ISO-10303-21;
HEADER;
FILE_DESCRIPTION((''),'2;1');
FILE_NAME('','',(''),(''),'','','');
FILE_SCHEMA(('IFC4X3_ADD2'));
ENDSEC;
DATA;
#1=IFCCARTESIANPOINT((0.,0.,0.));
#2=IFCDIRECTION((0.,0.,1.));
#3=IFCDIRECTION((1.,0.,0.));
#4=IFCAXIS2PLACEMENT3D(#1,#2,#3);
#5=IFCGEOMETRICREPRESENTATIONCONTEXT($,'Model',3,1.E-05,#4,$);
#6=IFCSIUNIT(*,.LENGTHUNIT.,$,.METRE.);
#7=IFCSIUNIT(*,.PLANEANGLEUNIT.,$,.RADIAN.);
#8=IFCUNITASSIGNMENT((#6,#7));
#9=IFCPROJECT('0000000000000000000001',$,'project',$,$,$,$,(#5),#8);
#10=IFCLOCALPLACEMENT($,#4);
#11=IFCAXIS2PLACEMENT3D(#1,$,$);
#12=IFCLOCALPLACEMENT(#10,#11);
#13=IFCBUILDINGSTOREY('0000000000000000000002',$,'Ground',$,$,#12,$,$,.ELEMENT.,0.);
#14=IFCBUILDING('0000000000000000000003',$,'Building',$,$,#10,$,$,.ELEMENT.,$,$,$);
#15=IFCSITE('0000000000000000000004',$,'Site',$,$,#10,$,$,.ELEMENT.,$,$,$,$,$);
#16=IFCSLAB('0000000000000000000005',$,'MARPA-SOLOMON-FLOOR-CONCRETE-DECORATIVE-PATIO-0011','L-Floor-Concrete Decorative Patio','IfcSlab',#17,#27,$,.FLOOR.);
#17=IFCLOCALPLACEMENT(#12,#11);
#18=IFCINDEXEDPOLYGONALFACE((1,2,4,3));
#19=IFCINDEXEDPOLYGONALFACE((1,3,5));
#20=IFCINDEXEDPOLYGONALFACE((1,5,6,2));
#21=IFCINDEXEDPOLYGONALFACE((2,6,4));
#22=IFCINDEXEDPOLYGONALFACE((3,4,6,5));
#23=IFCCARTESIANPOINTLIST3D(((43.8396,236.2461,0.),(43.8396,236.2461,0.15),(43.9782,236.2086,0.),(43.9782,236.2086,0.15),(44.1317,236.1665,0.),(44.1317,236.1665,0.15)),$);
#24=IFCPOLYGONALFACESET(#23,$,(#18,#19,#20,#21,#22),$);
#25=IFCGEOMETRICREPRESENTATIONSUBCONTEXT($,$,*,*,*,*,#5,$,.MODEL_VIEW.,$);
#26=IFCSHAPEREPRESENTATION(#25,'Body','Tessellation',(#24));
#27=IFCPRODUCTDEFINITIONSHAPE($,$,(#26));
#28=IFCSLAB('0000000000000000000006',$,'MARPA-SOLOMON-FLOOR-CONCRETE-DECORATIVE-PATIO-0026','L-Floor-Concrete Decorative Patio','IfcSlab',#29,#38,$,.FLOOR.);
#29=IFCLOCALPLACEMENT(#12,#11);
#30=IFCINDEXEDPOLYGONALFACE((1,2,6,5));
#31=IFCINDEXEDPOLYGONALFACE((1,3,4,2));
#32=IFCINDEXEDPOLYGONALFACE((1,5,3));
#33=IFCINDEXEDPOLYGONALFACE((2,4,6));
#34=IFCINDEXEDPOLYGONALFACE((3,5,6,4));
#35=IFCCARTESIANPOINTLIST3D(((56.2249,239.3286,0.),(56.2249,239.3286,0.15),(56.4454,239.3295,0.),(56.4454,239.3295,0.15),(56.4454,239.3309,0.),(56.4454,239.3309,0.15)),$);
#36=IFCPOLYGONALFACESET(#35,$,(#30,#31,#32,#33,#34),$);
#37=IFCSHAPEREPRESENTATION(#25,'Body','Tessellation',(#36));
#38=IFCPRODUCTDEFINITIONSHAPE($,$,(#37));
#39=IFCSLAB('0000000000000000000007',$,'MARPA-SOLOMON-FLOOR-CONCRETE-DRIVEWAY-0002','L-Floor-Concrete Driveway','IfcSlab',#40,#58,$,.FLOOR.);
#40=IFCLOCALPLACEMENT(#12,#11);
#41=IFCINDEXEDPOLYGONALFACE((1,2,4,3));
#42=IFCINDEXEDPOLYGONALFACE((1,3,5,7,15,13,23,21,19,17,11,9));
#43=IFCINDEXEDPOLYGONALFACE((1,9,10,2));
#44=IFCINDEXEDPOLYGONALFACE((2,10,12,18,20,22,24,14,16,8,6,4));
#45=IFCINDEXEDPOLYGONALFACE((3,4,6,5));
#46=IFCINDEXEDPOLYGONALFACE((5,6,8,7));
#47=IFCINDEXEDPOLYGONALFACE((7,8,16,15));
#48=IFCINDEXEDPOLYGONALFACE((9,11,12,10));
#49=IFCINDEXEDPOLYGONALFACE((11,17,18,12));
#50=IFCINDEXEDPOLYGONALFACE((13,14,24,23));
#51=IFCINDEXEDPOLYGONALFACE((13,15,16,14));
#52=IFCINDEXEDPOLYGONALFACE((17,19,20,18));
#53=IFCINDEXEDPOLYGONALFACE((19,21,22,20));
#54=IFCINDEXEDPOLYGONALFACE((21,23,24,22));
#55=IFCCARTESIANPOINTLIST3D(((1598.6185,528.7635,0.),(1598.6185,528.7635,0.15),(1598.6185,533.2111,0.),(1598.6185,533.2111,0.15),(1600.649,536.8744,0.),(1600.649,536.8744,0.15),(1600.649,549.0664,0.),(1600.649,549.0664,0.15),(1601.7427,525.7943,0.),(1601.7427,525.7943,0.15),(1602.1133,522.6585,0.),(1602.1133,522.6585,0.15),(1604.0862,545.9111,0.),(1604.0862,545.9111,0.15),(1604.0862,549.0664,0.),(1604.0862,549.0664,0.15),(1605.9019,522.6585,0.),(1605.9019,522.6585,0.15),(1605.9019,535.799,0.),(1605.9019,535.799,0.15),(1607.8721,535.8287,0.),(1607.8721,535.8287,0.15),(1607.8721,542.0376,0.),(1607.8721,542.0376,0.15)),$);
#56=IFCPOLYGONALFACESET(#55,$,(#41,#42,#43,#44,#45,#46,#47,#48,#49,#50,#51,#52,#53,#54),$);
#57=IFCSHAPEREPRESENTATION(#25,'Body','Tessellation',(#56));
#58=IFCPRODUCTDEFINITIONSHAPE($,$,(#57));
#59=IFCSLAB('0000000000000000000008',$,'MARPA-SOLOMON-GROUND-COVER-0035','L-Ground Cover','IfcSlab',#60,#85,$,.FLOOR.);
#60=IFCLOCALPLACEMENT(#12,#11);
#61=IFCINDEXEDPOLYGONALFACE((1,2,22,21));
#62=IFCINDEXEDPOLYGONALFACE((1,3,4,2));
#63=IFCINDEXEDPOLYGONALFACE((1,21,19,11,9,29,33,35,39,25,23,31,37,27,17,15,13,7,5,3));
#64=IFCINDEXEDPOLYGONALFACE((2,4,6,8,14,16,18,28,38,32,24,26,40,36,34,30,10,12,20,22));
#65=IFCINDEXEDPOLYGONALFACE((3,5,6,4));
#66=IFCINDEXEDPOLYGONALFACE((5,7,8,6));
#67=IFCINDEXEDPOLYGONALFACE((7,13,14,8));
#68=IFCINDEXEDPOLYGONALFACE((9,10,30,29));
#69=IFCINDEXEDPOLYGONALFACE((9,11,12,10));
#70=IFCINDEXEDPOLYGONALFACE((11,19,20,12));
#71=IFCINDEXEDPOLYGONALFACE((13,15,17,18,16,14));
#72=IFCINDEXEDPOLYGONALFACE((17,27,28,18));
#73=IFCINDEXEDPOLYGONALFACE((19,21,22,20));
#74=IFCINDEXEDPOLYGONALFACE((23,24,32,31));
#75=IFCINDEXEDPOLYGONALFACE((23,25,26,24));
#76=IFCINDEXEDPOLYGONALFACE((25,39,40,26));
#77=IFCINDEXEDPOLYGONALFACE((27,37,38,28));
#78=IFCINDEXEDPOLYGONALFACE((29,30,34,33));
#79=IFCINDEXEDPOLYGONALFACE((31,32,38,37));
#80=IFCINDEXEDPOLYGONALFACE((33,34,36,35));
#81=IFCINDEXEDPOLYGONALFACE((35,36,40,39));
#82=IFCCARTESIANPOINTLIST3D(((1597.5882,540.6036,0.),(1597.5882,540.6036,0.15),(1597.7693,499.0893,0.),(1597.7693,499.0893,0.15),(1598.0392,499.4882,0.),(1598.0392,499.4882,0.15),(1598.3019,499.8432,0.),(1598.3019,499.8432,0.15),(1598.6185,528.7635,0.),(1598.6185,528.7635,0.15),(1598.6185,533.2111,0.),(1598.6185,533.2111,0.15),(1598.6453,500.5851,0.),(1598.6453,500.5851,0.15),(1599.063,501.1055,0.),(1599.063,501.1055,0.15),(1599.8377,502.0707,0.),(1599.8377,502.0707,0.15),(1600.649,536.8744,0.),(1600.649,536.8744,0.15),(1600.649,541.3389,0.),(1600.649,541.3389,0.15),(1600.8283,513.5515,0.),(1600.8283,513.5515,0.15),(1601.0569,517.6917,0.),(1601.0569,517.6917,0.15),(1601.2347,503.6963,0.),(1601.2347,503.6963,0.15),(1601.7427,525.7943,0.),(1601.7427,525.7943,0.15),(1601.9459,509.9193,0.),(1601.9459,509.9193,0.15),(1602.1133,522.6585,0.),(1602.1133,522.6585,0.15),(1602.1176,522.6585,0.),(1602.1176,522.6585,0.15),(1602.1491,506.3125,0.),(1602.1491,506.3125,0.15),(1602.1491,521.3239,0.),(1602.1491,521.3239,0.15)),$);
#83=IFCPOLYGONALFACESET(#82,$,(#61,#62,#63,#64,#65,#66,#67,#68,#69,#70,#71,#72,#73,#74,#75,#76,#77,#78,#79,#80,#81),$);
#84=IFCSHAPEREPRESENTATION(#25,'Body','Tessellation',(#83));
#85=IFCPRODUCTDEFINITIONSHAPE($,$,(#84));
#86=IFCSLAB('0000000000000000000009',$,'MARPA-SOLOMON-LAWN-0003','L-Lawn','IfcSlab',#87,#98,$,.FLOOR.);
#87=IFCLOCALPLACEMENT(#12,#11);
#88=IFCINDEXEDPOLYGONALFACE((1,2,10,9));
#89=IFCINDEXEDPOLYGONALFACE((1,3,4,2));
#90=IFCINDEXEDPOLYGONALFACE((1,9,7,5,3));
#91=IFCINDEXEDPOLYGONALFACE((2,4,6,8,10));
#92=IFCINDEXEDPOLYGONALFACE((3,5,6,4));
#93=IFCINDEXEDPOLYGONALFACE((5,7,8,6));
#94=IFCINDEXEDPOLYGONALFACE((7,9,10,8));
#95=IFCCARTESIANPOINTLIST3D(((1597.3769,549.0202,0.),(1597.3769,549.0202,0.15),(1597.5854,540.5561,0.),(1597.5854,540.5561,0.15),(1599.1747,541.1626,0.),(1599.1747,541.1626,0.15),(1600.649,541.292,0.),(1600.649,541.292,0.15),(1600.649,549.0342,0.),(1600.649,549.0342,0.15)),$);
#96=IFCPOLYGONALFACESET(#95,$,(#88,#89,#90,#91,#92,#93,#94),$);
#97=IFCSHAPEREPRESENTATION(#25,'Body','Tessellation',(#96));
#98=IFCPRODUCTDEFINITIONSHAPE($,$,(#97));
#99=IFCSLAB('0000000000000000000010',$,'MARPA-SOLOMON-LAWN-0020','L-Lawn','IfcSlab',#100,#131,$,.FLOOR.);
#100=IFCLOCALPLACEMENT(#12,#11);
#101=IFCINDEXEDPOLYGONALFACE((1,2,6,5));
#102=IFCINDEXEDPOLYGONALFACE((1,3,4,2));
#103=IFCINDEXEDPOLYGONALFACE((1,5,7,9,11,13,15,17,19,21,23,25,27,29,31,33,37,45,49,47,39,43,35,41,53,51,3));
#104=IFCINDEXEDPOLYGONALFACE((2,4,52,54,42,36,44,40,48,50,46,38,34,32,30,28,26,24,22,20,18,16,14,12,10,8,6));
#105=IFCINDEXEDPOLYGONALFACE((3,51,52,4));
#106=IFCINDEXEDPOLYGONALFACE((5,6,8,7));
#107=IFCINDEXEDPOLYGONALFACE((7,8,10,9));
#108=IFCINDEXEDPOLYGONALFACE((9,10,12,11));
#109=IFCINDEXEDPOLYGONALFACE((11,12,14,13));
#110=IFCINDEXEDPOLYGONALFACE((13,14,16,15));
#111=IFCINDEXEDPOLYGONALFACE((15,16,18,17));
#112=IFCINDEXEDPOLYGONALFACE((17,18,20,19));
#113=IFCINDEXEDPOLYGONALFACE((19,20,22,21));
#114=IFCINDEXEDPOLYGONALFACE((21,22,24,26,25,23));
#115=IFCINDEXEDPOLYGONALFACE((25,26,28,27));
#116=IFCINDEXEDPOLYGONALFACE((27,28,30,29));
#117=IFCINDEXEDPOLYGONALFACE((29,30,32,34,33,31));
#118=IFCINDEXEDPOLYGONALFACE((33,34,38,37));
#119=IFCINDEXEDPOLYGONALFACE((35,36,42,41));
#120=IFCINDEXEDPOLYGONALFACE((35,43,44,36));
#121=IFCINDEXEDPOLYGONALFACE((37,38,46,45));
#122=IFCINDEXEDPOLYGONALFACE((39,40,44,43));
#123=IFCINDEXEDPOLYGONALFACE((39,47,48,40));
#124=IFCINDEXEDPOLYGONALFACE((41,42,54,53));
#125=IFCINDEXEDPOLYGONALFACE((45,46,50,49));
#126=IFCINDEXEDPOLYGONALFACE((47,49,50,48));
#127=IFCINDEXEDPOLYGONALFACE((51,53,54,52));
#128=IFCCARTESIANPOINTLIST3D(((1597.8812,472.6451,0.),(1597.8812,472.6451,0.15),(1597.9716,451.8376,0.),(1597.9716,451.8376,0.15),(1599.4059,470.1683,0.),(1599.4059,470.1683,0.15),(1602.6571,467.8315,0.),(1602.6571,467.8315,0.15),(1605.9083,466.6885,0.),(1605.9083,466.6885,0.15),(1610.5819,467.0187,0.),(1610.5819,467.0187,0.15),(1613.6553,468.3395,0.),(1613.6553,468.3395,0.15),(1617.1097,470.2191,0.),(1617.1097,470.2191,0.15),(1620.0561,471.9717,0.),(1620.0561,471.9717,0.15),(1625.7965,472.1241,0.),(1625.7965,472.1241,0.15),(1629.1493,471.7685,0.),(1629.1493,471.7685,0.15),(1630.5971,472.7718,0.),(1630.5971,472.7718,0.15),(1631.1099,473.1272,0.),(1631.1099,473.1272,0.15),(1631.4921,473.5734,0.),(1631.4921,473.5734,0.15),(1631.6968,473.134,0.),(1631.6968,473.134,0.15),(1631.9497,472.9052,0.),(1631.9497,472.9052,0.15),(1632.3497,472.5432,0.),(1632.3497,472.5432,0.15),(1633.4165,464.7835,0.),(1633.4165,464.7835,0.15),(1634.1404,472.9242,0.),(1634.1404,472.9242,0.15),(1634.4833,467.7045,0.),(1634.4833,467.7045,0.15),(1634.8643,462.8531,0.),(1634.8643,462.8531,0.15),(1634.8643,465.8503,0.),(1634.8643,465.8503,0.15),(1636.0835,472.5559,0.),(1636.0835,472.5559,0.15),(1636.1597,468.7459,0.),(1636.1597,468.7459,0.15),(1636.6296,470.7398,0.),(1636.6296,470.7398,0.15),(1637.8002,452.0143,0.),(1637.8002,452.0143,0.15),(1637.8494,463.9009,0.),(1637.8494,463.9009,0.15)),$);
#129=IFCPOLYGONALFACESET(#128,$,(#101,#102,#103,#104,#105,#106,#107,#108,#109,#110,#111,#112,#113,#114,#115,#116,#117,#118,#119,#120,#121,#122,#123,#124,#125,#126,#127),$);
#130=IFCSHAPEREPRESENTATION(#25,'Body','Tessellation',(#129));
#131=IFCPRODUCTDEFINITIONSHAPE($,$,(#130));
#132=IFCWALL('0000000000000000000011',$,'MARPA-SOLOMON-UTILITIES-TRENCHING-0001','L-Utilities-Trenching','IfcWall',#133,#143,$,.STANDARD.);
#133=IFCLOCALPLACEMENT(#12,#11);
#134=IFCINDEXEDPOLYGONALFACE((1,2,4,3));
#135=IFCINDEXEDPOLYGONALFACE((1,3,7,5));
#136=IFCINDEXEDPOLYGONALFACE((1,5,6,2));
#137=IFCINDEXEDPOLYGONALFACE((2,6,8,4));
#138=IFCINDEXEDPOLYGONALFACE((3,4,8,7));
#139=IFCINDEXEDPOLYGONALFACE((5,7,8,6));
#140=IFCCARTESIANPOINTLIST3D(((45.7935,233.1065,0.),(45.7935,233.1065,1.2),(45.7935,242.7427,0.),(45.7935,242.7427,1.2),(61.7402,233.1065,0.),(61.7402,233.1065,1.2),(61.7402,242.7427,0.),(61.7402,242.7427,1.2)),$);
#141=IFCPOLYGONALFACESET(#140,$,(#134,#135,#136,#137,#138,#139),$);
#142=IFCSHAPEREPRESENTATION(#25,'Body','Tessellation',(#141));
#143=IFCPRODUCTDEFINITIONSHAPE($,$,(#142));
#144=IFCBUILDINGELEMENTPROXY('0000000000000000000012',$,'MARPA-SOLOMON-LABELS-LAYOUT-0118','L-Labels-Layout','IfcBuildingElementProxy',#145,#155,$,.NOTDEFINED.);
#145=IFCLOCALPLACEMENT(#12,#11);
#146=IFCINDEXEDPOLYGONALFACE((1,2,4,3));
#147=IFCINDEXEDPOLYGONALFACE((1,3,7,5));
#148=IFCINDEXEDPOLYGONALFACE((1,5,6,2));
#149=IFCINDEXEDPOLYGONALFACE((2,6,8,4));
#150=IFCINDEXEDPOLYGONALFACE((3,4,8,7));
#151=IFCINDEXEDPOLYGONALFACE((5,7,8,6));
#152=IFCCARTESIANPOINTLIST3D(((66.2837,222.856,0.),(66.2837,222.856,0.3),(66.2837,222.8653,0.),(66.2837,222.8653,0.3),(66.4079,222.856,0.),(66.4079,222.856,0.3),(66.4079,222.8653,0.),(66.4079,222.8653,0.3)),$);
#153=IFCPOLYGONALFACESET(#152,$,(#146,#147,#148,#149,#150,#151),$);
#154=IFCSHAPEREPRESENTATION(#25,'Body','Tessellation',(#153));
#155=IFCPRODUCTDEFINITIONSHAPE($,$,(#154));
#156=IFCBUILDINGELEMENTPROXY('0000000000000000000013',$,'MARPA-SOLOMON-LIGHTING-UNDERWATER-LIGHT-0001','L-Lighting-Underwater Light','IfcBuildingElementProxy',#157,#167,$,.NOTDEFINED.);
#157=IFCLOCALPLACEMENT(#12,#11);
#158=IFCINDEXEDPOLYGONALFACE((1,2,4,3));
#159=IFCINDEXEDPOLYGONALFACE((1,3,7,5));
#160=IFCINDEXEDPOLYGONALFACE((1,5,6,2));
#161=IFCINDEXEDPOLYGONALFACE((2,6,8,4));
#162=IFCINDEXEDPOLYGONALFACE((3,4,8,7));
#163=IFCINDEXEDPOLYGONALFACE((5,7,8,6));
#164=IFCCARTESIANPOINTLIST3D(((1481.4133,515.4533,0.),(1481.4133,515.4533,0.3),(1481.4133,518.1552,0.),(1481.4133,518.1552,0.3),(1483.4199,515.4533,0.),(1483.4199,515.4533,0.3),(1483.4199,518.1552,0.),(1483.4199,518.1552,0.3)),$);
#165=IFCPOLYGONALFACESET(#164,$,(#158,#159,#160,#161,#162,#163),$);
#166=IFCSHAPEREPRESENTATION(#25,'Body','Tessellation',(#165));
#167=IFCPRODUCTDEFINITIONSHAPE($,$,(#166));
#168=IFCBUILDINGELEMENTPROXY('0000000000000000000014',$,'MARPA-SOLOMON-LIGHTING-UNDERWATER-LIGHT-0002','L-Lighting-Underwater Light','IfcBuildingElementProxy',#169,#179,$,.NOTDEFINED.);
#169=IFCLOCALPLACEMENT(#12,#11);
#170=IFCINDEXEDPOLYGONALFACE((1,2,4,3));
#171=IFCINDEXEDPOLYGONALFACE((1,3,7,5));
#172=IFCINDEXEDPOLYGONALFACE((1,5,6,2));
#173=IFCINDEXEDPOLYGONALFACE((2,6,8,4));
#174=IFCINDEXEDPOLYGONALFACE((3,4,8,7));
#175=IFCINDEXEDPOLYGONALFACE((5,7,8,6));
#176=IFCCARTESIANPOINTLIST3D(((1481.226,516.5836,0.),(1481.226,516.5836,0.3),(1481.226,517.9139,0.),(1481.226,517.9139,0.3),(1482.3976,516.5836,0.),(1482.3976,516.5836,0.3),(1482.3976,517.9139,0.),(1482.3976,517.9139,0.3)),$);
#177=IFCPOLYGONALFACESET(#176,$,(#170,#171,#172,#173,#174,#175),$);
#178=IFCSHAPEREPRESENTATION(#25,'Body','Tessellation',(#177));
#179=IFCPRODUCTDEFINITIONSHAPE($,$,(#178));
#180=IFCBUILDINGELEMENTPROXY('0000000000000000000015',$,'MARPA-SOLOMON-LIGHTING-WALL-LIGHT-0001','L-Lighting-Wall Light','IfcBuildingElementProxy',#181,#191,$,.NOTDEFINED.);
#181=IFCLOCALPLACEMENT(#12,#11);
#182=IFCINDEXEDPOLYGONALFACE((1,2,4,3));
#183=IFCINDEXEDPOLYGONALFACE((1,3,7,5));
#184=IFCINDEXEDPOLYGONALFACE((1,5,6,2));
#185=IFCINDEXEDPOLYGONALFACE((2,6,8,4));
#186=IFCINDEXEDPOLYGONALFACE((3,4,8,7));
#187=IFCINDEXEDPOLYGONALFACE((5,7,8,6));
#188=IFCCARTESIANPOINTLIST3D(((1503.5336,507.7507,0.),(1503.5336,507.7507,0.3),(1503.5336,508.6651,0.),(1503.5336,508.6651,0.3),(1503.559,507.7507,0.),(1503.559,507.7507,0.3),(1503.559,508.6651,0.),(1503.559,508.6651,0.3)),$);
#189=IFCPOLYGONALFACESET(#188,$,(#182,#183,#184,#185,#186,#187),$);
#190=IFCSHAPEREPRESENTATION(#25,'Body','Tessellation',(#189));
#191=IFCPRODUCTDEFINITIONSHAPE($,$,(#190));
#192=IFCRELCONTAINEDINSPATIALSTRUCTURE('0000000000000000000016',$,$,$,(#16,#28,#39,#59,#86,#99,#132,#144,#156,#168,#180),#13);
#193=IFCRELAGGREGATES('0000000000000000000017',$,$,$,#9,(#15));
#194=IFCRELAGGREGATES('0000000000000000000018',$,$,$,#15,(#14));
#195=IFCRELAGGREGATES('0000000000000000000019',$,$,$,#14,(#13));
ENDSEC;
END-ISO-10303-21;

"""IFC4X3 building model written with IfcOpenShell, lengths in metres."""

from ifc_helpers import new_model, si_unit, frame, frame_2d, origin, origin_with_axes, place, context, subcontext, project, spatial, polyline, rectangle, outline, extrude, element, save


model = new_model("IFC4X3")

# Units and contexts
model_context = context("Model", 3, precision=1e-05, world=origin_with_axes())
sub_context = subcontext(model_context, None, None, "MODEL_VIEW")
ifc_project = project(units=[si_unit("LENGTHUNIT", "METRE"), si_unit("PLANEANGLEUNIT", "RADIAN")], contexts=[model_context])

# Site, building, storey
placement = place(None, origin_with_axes())
site = spatial("IfcSite", under=ifc_project, at=placement, Name="Site", CompositionType="ELEMENT")
building = spatial("IfcBuilding", under=site, at=placement, Name="Building", CompositionType="ELEMENT")
storey_placement = place(placement, origin())
storey = spatial("IfcBuildingStorey", under=building, at=storey_placement, Name="Ground", CompositionType="ELEMENT", Elevation=0.0)

# Slabs
slab_1_placement = place(storey_placement, frame((43.8396, 236.1665, 0.0)))
element("IfcSlab", 1, at=slab_1_placement, inside=storey, Name="MARPA-SOLOMON-FLOOR-CONCRETE-DECORATIVE-PATIO-0011", Description="L-Floor-Concrete Decorative Patio", ObjectType="IfcSlab", PredefinedType="FLOOR", context=sub_context, shape_type="SweptSolid", body=[
    extrude(outline(polyline([(0.0, 0.0796), (0.2921, 0.0), (0.1386, 0.0421), (0.0, 0.0796)])), origin(), (0.0, 0.0, 1.0), 0.15),
])
slab_2_placement = place(storey_placement, frame((56.2249, 239.3286, 0.0)))
element("IfcSlab", 2, at=slab_2_placement, inside=storey, Name="MARPA-SOLOMON-FLOOR-CONCRETE-DECORATIVE-PATIO-0026", Description="L-Floor-Concrete Decorative Patio", ObjectType="IfcSlab", PredefinedType="FLOOR", context=sub_context, shape_type="SweptSolid", body=[
    extrude(outline(polyline([(0.0, 0.0), (0.2205, 0.001), (0.2205, 0.0023), (0.0, 0.0)])), origin(), (0.0, 0.0, 1.0), 0.15),
])
slab_3_placement = place(storey_placement, frame((1598.6185, 522.6585, 0.0)))
element("IfcSlab", 3, at=slab_3_placement, inside=storey, Name="MARPA-SOLOMON-FLOOR-CONCRETE-DRIVEWAY-0002", Description="L-Floor-Concrete Driveway", ObjectType="IfcSlab", PredefinedType="FLOOR", context=sub_context, shape_type="SweptSolid", body=[
    extrude(outline(polyline([(2.0305, 26.4079), (2.0305, 14.2159), (0.0, 10.5527), (0.0, 6.105), (3.1242, 3.1359), (3.4948, 0.0), (7.2834, 0.0), (7.2834, 13.1405), (9.2536, 13.1702), (9.2536, 19.3792), (5.4677, 23.2527), (5.4677, 26.4079), (2.0305, 26.4079)])), origin(), (0.0, 0.0, 1.0), 0.15),
])
slab_4_placement = place(storey_placement, frame((1597.5882, 499.0893, 0.0)))
element("IfcSlab", 4, at=slab_4_placement, inside=storey, Name="MARPA-SOLOMON-GROUND-COVER-0035", Description="L-Ground Cover", ObjectType="IfcSlab", PredefinedType="FLOOR", context=sub_context, shape_type="SweptSolid", body=[
    extrude(outline(polyline([(0.7137, 0.7538), (1.0571, 1.4958), (1.4748, 2.0162), (2.2495, 2.9814), (3.6465, 4.607), (4.5609, 7.2232), (4.3577, 10.83), (3.2401, 14.4622), (3.4687, 18.6024), (4.5609, 22.2346), (4.5294, 23.5691), (4.5251, 23.5691), (4.1545, 26.705), (1.0303, 29.6741), (1.0303, 34.1218), (3.0608, 37.785), (3.0608, 42.2496), (0.0, 41.5143), (0.1811, 0.0), (0.451, 0.3989), (0.7137, 0.7538)])), origin(), (0.0, 0.0, 1.0), 0.15),
])
slab_5_placement = place(storey_placement, frame((1597.3769, 540.5561, 0.0)))
element("IfcSlab", 5, at=slab_5_placement, inside=storey, Name="MARPA-SOLOMON-LAWN-0003", Description="L-Lawn", ObjectType="IfcSlab", PredefinedType="FLOOR", context=sub_context, shape_type="SweptSolid", body=[
    extrude(outline(polyline([(3.2721, 0.7359), (3.2721, 8.4781), (0.0, 8.4641), (0.2085, 0.0), (1.7978, 0.6065), (3.2721, 0.7359)])), origin(), (0.0, 0.0, 1.0), 0.15),
])
slab_6_placement = place(storey_placement, frame((1597.8812, 451.8376, 0.0)))
element("IfcSlab", 6, at=slab_6_placement, inside=storey, Name="MARPA-SOLOMON-LAWN-0020", Description="L-Lawn", ObjectType="IfcSlab", PredefinedType="FLOOR", context=sub_context, shape_type="SweptSolid", body=[
    extrude(outline(polyline([(33.6109, 21.7358), (33.2287, 21.2896), (32.7159, 20.9343), (31.2681, 19.931), (27.9153, 20.2866), (22.1749, 20.1342), (19.2285, 18.3816), (15.7741, 16.502), (12.7007, 15.1812), (8.0271, 14.851), (4.7759, 15.994), (1.5247, 18.3308), (0.0, 20.8075), (0.0904, 0.0), (39.919, 0.1767), (39.9682, 12.0633), (36.9831, 11.0156), (35.5353, 12.946), (36.9831, 14.0128), (36.6021, 15.867), (38.2785, 16.9084), (38.7484, 18.9023), (38.2023, 20.7184), (36.2592, 21.0867), (34.4685, 20.7057), (34.0684, 21.0676), (33.8156, 21.2964), (33.6109, 21.7358)])), origin(), (0.0, 0.0, 1.0), 0.15),
])

# Wall
wall_placement = place(storey_placement, frame((45.7935, 237.9246, 0.0), x_axis=(1.0, 0.0, 0.0)))
element("IfcWall", 7, at=wall_placement, inside=storey, Name="MARPA-SOLOMON-UTILITIES-TRENCHING-0001", Description="L-Utilities-Trenching", ObjectType="IfcWall", PredefinedType="STANDARD", context=sub_context, shape_type="SweptSolid", body=[
    extrude(rectangle(XDim=15.9467, YDim=9.6362, at=frame_2d((7.9733, 0.0))), origin(), (0.0, 0.0, 1.0), 1.2),
])

# Building element proxies
proxy_1_placement = place(placement, frame((66.2837, 222.856, 0.0)))
element("IfcBuildingElementProxy", 8, at=proxy_1_placement, inside=storey, Name="MARPA-SOLOMON-LABELS-LAYOUT-0118", Description="L-Labels-Layout", ObjectType="IfcBuildingElementProxy", PredefinedType="NOTDEFINED", context=sub_context, shape_type="SweptSolid", body=[
    extrude(outline(polyline([(0.0, 0.0), (0.0, 0.0093), (0.1242, 0.0093), (0.1242, 0.0), (0.0, 0.0)])), origin(), (0.0, 0.0, 1.0), 0.3),
])
proxy_2_placement = place(placement, frame((1481.4133, 515.4533, 0.0)))
element("IfcBuildingElementProxy", 9, at=proxy_2_placement, inside=storey, Name="MARPA-SOLOMON-LIGHTING-UNDERWATER-LIGHT-0001", Description="L-Lighting-Underwater Light", ObjectType="IfcBuildingElementProxy", PredefinedType="NOTDEFINED", context=sub_context, shape_type="SweptSolid", body=[
    extrude(rectangle(XDim=2.0066, YDim=2.7019, at=frame_2d((1.0033, 1.351))), origin(), (0.0, 0.0, 1.0), 0.3),
])
proxy_3_placement = place(placement, frame((1481.226, 516.5836, 0.0)))
element("IfcBuildingElementProxy", 10, at=proxy_3_placement, inside=storey, Name="MARPA-SOLOMON-LIGHTING-UNDERWATER-LIGHT-0002", Description="L-Lighting-Underwater Light", ObjectType="IfcBuildingElementProxy", PredefinedType="NOTDEFINED", context=sub_context, shape_type="SweptSolid", body=[
    extrude(rectangle(XDim=1.1716, YDim=1.3303, at=frame_2d((0.5858, 0.6652))), origin(), (0.0, 0.0, 1.0), 0.3),
])
proxy_4_placement = place(placement, frame((1503.5336, 507.7507, 0.0)))
element("IfcBuildingElementProxy", 11, at=proxy_4_placement, inside=storey, Name="MARPA-SOLOMON-LIGHTING-WALL-LIGHT-0001", Description="L-Lighting-Wall Light", ObjectType="IfcBuildingElementProxy", PredefinedType="NOTDEFINED", context=sub_context, shape_type="SweptSolid", body=[
    extrude(outline(polyline([(0.0254, 0.0), (0.0, 0.0), (0.0, 0.9144), (0.0254, 0.9144), (0.0254, 0.0)])), origin(), (0.0, 0.0, 1.0), 0.3),
])

save(model, "model.ifc")
